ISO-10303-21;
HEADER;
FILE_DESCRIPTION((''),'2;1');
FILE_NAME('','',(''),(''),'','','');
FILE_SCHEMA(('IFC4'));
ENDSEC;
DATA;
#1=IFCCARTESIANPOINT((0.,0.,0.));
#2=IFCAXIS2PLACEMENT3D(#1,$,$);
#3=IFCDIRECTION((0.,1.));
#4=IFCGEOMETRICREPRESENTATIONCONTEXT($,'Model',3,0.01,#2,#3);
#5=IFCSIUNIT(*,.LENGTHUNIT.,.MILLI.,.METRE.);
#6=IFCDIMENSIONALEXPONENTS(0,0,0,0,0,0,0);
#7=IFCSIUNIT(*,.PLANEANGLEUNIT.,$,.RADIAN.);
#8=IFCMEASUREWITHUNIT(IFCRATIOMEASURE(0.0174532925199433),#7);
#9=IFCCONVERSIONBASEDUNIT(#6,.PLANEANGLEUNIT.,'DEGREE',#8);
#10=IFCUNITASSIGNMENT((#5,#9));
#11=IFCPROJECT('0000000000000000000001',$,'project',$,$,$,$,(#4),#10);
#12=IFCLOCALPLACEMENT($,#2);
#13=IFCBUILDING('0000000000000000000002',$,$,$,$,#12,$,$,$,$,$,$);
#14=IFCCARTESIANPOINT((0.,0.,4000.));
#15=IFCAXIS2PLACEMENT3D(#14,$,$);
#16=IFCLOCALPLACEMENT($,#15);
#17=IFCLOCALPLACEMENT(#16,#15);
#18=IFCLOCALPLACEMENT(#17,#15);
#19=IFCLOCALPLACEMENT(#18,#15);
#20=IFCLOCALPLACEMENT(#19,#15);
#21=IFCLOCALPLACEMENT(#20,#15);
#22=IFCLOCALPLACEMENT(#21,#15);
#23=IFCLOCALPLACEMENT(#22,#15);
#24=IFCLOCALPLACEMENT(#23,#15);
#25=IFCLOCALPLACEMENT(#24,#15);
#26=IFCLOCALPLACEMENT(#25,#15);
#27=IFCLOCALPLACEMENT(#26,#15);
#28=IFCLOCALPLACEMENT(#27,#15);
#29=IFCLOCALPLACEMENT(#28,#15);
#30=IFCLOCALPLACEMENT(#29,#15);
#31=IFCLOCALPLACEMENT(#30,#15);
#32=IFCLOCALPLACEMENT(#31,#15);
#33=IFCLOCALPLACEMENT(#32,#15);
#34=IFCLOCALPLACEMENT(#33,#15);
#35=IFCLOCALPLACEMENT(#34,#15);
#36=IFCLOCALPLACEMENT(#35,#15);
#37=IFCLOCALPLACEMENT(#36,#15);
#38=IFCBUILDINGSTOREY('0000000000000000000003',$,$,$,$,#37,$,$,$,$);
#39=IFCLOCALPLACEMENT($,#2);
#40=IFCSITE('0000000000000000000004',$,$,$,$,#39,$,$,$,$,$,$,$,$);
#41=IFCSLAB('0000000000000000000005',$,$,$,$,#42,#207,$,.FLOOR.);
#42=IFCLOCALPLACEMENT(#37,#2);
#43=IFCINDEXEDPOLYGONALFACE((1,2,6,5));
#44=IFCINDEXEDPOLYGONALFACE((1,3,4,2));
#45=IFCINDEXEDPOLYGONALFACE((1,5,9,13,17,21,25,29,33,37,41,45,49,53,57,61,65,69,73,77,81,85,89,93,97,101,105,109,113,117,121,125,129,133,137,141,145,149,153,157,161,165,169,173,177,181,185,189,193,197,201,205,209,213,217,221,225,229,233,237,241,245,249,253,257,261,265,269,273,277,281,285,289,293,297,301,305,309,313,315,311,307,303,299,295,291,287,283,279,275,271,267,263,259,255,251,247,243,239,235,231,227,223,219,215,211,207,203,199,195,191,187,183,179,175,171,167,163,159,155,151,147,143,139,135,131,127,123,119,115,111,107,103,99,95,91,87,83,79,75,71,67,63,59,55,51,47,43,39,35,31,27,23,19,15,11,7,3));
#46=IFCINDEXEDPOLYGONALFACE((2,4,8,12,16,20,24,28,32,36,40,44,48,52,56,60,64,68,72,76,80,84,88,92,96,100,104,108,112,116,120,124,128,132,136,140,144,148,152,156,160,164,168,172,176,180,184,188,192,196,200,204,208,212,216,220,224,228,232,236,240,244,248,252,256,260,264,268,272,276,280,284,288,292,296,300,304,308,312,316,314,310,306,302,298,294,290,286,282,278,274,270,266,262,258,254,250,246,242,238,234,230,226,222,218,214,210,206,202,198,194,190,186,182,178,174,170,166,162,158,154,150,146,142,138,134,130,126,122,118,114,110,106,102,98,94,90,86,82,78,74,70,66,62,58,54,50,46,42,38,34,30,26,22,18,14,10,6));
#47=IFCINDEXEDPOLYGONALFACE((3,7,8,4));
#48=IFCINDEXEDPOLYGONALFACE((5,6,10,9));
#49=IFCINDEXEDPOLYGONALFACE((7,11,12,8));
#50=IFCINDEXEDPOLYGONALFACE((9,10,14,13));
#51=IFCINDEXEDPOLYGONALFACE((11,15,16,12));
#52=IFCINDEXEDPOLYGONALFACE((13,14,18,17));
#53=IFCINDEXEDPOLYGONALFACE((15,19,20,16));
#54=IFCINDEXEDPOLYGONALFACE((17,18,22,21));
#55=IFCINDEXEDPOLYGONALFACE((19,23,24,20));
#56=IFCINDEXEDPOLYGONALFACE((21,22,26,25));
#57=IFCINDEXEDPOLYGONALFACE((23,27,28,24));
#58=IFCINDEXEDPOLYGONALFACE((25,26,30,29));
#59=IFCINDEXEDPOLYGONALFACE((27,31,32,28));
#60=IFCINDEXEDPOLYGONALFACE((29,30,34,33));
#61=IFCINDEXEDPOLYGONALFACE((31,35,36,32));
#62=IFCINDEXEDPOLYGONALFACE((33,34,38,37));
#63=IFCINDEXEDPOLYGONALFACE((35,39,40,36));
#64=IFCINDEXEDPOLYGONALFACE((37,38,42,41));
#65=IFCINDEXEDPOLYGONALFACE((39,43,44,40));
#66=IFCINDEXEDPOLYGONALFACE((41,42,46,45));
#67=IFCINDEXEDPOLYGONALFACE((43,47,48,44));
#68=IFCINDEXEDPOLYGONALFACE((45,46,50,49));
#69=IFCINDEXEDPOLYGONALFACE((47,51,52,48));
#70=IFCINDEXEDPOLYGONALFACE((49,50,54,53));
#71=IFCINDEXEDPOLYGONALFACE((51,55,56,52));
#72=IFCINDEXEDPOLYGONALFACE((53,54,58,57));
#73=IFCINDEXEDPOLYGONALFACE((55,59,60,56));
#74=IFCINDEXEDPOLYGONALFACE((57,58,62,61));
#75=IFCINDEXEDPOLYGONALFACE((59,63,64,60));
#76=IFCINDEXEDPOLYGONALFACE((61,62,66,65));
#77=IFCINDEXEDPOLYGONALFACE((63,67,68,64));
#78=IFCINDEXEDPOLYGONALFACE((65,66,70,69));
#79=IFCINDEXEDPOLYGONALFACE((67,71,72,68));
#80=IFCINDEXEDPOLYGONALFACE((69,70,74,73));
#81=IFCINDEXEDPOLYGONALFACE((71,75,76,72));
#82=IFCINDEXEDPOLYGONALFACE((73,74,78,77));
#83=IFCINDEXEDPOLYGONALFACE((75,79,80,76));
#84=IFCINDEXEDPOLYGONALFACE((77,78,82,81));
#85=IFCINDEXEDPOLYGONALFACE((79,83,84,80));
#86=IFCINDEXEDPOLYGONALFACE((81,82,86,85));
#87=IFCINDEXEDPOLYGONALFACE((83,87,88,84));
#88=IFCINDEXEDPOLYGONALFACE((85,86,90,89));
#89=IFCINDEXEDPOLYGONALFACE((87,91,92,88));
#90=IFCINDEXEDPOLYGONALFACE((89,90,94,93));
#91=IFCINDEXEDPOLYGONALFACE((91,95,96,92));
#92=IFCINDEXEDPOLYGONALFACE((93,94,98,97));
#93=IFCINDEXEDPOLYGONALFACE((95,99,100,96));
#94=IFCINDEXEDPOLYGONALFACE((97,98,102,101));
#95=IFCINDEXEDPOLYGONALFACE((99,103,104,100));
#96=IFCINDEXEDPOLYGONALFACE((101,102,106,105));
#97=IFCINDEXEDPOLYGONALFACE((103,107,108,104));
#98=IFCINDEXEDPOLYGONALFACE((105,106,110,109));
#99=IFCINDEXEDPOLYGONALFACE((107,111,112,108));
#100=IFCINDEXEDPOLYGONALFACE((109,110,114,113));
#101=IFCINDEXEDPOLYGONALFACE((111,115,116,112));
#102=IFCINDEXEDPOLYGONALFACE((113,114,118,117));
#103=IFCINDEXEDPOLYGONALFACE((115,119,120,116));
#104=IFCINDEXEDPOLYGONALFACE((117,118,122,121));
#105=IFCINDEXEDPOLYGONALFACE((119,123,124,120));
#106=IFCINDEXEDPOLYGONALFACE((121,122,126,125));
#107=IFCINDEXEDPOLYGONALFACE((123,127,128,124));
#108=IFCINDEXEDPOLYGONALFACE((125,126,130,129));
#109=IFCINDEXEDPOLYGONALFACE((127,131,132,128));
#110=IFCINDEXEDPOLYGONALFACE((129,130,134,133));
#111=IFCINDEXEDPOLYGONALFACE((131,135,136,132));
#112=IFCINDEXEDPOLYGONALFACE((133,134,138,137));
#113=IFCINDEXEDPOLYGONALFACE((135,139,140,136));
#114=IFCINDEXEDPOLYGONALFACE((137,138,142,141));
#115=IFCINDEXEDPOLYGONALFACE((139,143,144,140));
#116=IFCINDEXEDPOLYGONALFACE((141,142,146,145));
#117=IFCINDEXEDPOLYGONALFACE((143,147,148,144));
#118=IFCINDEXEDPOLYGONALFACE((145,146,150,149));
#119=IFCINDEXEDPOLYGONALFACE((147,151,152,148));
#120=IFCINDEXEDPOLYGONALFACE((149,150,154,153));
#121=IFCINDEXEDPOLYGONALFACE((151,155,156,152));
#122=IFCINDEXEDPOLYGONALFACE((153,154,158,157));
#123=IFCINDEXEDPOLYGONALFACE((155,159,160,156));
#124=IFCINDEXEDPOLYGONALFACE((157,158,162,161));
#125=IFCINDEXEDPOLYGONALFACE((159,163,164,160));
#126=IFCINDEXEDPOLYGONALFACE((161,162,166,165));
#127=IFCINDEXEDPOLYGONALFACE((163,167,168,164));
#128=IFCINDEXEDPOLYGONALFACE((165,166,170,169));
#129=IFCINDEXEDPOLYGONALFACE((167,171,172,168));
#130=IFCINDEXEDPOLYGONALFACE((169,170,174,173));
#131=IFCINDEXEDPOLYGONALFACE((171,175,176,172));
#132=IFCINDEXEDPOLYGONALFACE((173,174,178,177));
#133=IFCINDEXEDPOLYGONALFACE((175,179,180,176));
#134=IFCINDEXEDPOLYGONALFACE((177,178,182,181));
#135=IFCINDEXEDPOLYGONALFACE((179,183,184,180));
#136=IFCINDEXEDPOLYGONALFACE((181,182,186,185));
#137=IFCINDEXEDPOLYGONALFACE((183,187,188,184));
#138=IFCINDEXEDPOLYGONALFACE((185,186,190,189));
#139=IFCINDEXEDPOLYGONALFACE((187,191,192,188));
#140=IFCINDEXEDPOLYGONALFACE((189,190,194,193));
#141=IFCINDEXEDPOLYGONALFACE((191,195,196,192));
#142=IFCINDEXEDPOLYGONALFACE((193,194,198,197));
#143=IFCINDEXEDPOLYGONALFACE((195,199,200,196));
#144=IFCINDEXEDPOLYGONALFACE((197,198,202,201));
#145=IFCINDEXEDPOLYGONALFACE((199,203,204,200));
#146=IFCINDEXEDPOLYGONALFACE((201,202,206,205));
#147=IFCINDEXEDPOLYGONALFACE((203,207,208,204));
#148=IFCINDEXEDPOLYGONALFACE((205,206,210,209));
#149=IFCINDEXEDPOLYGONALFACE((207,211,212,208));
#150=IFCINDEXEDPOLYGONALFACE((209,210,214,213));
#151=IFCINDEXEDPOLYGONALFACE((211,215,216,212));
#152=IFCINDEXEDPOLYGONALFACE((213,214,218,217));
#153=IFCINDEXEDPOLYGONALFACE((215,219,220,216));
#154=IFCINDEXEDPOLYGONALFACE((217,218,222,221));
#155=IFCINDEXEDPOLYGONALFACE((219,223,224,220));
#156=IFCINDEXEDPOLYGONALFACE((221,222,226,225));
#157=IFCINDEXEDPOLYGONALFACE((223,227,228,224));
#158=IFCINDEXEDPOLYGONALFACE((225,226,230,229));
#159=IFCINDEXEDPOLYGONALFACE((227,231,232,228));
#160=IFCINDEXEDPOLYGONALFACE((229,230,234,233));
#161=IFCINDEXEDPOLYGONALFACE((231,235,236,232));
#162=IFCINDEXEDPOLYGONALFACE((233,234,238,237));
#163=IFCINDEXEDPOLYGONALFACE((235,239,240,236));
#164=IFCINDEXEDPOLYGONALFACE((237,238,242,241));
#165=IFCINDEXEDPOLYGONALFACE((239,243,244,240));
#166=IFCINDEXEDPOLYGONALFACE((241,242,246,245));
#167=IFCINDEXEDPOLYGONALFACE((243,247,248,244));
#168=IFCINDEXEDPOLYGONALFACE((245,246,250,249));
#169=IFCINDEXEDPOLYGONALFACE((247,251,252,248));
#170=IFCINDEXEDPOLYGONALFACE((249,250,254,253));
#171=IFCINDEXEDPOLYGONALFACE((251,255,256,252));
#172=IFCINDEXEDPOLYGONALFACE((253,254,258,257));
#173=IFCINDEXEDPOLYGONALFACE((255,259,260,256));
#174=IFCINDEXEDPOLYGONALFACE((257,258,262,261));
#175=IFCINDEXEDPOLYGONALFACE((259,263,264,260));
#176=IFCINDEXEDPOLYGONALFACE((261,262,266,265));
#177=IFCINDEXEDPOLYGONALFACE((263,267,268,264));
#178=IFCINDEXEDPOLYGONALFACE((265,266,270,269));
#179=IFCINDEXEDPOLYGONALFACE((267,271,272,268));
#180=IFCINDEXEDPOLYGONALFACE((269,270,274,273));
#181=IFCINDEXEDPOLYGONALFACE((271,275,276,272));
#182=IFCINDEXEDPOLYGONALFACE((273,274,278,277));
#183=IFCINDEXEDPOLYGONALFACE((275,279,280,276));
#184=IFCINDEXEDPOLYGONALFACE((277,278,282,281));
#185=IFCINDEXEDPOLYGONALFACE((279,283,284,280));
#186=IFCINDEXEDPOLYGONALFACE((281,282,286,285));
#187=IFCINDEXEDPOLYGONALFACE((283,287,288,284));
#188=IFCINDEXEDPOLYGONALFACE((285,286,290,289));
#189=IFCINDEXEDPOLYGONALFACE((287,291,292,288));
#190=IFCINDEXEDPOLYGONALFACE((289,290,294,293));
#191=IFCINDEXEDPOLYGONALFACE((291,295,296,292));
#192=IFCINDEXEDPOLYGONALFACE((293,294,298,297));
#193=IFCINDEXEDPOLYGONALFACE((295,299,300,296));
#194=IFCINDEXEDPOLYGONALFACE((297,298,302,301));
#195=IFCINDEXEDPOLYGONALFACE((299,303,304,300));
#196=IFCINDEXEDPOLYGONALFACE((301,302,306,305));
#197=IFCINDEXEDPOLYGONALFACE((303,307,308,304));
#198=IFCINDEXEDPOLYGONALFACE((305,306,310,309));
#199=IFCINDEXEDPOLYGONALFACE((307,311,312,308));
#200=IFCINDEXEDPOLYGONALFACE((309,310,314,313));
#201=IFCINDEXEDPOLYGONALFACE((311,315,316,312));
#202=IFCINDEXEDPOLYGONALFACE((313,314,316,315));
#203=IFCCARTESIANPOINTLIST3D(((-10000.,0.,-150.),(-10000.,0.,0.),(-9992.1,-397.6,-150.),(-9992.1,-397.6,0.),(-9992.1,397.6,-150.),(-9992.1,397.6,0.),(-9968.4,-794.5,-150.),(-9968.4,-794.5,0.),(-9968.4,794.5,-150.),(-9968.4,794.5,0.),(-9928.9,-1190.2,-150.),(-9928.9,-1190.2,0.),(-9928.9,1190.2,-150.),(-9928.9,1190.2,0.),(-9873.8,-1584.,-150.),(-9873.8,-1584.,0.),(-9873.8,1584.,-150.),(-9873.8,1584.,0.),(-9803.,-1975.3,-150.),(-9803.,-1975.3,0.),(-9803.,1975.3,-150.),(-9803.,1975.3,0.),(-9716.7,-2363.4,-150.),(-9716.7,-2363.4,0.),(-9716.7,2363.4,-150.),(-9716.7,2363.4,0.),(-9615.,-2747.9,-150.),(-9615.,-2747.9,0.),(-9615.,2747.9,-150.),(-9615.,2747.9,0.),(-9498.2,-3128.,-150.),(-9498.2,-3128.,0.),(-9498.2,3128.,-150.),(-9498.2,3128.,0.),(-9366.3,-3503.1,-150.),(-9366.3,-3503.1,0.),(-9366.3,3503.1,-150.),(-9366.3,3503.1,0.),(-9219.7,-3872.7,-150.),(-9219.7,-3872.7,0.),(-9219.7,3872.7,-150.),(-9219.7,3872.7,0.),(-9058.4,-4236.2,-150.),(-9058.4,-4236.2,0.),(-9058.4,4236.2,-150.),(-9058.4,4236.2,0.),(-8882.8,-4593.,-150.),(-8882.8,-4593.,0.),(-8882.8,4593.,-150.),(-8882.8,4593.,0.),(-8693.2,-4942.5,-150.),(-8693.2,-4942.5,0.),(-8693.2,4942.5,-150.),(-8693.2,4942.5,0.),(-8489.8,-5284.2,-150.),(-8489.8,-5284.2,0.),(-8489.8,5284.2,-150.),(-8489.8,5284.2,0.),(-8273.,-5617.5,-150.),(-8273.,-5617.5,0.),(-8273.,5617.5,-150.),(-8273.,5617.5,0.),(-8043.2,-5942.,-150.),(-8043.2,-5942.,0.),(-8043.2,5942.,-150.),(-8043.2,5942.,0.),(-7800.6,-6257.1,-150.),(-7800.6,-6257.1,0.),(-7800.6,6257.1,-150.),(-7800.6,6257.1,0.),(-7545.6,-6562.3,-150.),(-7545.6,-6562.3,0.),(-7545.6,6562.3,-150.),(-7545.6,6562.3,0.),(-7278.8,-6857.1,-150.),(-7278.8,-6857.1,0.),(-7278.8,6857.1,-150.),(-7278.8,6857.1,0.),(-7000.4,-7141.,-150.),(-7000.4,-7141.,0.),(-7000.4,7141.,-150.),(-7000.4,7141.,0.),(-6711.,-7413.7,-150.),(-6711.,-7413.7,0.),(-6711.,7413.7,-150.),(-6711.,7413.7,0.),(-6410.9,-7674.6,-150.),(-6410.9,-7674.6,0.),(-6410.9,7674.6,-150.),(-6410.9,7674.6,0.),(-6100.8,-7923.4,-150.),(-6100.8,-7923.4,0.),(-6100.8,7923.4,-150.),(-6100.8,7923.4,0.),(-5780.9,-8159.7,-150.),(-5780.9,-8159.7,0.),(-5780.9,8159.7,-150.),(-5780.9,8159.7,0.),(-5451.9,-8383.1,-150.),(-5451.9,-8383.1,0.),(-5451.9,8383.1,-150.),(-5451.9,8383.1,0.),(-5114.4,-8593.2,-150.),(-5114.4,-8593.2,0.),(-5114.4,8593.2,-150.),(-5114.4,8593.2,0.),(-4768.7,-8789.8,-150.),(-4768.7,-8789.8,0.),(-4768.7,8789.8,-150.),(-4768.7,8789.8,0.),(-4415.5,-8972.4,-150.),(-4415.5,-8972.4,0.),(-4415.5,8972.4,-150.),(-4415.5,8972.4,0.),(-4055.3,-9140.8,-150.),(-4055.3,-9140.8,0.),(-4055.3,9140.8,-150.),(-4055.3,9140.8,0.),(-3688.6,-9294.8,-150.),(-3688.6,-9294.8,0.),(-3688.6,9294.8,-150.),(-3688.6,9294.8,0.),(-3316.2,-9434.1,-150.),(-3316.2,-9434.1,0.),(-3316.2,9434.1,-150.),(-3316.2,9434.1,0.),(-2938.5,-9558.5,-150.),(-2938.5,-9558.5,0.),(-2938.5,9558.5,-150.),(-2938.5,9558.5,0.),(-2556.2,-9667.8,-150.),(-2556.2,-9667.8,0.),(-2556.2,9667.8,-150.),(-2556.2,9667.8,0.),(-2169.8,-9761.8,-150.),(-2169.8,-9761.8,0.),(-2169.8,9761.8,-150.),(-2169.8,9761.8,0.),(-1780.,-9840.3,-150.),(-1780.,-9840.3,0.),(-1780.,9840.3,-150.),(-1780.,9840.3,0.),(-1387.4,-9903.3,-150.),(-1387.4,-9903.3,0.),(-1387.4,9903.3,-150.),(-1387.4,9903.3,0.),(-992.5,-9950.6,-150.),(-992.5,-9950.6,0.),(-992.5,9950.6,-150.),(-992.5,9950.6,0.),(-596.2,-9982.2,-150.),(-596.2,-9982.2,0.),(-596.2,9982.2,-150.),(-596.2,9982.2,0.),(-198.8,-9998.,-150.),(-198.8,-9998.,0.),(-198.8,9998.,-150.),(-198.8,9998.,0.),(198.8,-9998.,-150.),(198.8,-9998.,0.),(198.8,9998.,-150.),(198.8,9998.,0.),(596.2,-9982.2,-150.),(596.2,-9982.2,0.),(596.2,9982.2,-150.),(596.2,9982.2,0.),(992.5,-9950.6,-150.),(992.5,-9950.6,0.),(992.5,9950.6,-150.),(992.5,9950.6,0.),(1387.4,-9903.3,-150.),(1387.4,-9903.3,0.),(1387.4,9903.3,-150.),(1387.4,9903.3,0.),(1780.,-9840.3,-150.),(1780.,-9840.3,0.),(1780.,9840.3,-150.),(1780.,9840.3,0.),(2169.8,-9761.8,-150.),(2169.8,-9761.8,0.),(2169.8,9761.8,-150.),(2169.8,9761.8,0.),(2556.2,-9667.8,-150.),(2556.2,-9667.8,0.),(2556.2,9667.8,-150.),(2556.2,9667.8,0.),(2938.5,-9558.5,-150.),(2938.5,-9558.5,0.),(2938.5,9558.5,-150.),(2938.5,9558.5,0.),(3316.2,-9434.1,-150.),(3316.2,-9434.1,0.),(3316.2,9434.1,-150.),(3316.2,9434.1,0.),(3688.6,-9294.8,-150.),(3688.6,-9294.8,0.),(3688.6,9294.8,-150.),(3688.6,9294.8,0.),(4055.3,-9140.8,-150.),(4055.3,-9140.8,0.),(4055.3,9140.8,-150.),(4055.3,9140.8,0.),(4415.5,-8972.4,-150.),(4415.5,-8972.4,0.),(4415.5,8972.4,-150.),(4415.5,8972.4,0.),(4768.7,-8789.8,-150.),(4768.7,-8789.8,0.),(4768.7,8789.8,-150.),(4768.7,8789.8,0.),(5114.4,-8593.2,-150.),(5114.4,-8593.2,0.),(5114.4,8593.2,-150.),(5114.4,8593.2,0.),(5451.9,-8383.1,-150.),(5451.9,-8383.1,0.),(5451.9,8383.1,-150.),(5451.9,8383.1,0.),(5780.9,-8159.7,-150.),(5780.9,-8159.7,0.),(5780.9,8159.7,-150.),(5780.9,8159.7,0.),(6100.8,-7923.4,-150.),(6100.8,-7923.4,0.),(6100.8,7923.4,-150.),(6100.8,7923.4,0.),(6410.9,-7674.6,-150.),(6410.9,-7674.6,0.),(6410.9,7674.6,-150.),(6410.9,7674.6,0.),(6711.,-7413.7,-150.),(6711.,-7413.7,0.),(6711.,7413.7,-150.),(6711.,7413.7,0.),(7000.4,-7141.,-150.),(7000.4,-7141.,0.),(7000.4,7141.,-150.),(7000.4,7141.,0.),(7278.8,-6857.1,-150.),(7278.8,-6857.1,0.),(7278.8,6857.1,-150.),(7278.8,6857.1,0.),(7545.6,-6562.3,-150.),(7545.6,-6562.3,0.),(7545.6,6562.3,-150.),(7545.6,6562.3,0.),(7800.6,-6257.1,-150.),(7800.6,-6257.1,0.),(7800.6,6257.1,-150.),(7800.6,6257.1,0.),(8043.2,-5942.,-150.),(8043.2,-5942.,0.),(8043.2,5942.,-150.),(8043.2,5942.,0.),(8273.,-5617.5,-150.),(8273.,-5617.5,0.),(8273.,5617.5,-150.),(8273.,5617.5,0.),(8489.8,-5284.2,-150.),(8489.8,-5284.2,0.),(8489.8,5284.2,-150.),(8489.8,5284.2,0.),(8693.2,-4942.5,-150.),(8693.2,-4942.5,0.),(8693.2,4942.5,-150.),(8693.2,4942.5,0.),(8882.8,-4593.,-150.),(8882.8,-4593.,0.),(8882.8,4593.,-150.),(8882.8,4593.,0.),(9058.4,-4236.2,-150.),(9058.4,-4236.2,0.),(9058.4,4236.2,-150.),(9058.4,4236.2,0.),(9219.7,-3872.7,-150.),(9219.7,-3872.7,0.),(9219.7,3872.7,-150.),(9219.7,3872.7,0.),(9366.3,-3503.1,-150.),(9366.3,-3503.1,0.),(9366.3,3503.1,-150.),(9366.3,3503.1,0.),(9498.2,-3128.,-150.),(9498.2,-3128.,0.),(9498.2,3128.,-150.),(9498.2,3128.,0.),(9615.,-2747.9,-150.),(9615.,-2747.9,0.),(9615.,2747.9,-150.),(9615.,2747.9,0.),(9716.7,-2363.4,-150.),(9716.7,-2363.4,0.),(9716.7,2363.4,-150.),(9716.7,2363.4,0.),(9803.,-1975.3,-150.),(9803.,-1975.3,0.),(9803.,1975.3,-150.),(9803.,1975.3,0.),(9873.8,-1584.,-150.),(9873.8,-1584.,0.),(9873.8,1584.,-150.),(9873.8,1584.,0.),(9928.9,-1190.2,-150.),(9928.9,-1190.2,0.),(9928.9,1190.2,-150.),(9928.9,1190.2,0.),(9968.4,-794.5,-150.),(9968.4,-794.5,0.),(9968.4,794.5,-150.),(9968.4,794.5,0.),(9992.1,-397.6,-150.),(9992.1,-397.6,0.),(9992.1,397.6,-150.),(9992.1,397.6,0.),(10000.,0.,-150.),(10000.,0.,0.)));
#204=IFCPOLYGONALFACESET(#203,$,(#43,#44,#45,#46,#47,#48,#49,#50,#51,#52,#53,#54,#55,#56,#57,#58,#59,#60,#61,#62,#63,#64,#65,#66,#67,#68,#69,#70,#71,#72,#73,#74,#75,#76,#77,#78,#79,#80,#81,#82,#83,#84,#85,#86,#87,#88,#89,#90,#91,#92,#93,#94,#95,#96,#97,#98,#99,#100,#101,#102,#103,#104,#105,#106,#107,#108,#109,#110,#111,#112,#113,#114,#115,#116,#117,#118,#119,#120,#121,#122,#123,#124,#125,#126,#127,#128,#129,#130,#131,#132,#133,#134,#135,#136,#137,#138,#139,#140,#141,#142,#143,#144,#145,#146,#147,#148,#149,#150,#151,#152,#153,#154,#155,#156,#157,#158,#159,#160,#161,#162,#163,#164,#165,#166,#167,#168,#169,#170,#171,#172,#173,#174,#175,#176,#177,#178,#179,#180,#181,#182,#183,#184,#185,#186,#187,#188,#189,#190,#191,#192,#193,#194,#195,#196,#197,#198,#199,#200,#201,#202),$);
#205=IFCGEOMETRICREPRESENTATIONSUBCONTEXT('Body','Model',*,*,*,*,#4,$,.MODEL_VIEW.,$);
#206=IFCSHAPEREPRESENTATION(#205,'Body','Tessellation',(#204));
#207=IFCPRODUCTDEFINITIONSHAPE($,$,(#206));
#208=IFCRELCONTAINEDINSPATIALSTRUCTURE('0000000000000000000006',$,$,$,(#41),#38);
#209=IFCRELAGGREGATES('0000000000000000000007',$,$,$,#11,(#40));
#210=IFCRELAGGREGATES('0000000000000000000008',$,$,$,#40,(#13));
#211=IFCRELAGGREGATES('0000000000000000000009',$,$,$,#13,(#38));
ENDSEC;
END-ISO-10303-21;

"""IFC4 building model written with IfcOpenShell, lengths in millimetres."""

from ifc_helpers import new_model, entity, si_unit, converted_unit, direction, frame, origin, origin_2d, place, context, subcontext, project, spatial, circle, extrude, element, save


model = new_model("IFC4")

# Units and contexts
model_context = context("Model", 3, precision=0.01, world=origin(), true_north=direction((0.0, 1.0)))
body_context = subcontext(model_context, "Body", "Model", "MODEL_VIEW")
ifc_project = project(units=[si_unit("LENGTHUNIT", "METRE", prefix="MILLI"), converted_unit("PLANEANGLEUNIT", "DEGREE", entity("IfcRatioMeasure", 0.0174532925199433), si_unit("PLANEANGLEUNIT", "RADIAN"), dimensions=[0, 0, 0, 0, 0, 0, 0])], contexts=[model_context])

# Site, building, storey
site_placement = place(None, origin())
site = spatial("IfcSite", under=ifc_project, at=site_placement)
building_placement = place(None, origin())
building = spatial("IfcBuilding", under=site, at=building_placement)
placement_1 = place(None, frame((0.0, 0.0, 4000.0)))
placement_2 = place(placement_1, frame((0.0, 0.0, 4000.0)))
placement_3 = place(placement_2, frame((0.0, 0.0, 4000.0)))
placement_4 = place(placement_3, frame((0.0, 0.0, 4000.0)))
placement_5 = place(placement_4, frame((0.0, 0.0, 4000.0)))
placement_6 = place(placement_5, frame((0.0, 0.0, 4000.0)))
placement_7 = place(placement_6, frame((0.0, 0.0, 4000.0)))
placement_8 = place(placement_7, frame((0.0, 0.0, 4000.0)))
placement_9 = place(placement_8, frame((0.0, 0.0, 4000.0)))
placement_10 = place(placement_9, frame((0.0, 0.0, 4000.0)))
placement_11 = place(placement_10, frame((0.0, 0.0, 4000.0)))
placement_12 = place(placement_11, frame((0.0, 0.0, 4000.0)))
placement_13 = place(placement_12, frame((0.0, 0.0, 4000.0)))
placement_14 = place(placement_13, frame((0.0, 0.0, 4000.0)))
placement_15 = place(placement_14, frame((0.0, 0.0, 4000.0)))
placement_16 = place(placement_15, frame((0.0, 0.0, 4000.0)))
placement_17 = place(placement_16, frame((0.0, 0.0, 4000.0)))
placement_18 = place(placement_17, frame((0.0, 0.0, 4000.0)))
placement_19 = place(placement_18, frame((0.0, 0.0, 4000.0)))
placement_20 = place(placement_19, frame((0.0, 0.0, 4000.0)))
placement_21 = place(placement_20, frame((0.0, 0.0, 4000.0)))
storey_placement = place(placement_21, frame((0.0, 0.0, 4000.0)))
storey = spatial("IfcBuildingStorey", under=building, at=storey_placement)

# Slab
slab_placement = place(storey_placement, frame((0.0, 0.0, -150.0)))
element("IfcSlab", 1, at=slab_placement, inside=storey, PredefinedType="FLOOR", context=body_context, shape_type="SweptSolid", body=[
    extrude(circle(Radius=10000.0, at=origin_2d()), origin(), (0.0, 0.0, 1.0), 150.0),
])

save(model, "model.ifc")
